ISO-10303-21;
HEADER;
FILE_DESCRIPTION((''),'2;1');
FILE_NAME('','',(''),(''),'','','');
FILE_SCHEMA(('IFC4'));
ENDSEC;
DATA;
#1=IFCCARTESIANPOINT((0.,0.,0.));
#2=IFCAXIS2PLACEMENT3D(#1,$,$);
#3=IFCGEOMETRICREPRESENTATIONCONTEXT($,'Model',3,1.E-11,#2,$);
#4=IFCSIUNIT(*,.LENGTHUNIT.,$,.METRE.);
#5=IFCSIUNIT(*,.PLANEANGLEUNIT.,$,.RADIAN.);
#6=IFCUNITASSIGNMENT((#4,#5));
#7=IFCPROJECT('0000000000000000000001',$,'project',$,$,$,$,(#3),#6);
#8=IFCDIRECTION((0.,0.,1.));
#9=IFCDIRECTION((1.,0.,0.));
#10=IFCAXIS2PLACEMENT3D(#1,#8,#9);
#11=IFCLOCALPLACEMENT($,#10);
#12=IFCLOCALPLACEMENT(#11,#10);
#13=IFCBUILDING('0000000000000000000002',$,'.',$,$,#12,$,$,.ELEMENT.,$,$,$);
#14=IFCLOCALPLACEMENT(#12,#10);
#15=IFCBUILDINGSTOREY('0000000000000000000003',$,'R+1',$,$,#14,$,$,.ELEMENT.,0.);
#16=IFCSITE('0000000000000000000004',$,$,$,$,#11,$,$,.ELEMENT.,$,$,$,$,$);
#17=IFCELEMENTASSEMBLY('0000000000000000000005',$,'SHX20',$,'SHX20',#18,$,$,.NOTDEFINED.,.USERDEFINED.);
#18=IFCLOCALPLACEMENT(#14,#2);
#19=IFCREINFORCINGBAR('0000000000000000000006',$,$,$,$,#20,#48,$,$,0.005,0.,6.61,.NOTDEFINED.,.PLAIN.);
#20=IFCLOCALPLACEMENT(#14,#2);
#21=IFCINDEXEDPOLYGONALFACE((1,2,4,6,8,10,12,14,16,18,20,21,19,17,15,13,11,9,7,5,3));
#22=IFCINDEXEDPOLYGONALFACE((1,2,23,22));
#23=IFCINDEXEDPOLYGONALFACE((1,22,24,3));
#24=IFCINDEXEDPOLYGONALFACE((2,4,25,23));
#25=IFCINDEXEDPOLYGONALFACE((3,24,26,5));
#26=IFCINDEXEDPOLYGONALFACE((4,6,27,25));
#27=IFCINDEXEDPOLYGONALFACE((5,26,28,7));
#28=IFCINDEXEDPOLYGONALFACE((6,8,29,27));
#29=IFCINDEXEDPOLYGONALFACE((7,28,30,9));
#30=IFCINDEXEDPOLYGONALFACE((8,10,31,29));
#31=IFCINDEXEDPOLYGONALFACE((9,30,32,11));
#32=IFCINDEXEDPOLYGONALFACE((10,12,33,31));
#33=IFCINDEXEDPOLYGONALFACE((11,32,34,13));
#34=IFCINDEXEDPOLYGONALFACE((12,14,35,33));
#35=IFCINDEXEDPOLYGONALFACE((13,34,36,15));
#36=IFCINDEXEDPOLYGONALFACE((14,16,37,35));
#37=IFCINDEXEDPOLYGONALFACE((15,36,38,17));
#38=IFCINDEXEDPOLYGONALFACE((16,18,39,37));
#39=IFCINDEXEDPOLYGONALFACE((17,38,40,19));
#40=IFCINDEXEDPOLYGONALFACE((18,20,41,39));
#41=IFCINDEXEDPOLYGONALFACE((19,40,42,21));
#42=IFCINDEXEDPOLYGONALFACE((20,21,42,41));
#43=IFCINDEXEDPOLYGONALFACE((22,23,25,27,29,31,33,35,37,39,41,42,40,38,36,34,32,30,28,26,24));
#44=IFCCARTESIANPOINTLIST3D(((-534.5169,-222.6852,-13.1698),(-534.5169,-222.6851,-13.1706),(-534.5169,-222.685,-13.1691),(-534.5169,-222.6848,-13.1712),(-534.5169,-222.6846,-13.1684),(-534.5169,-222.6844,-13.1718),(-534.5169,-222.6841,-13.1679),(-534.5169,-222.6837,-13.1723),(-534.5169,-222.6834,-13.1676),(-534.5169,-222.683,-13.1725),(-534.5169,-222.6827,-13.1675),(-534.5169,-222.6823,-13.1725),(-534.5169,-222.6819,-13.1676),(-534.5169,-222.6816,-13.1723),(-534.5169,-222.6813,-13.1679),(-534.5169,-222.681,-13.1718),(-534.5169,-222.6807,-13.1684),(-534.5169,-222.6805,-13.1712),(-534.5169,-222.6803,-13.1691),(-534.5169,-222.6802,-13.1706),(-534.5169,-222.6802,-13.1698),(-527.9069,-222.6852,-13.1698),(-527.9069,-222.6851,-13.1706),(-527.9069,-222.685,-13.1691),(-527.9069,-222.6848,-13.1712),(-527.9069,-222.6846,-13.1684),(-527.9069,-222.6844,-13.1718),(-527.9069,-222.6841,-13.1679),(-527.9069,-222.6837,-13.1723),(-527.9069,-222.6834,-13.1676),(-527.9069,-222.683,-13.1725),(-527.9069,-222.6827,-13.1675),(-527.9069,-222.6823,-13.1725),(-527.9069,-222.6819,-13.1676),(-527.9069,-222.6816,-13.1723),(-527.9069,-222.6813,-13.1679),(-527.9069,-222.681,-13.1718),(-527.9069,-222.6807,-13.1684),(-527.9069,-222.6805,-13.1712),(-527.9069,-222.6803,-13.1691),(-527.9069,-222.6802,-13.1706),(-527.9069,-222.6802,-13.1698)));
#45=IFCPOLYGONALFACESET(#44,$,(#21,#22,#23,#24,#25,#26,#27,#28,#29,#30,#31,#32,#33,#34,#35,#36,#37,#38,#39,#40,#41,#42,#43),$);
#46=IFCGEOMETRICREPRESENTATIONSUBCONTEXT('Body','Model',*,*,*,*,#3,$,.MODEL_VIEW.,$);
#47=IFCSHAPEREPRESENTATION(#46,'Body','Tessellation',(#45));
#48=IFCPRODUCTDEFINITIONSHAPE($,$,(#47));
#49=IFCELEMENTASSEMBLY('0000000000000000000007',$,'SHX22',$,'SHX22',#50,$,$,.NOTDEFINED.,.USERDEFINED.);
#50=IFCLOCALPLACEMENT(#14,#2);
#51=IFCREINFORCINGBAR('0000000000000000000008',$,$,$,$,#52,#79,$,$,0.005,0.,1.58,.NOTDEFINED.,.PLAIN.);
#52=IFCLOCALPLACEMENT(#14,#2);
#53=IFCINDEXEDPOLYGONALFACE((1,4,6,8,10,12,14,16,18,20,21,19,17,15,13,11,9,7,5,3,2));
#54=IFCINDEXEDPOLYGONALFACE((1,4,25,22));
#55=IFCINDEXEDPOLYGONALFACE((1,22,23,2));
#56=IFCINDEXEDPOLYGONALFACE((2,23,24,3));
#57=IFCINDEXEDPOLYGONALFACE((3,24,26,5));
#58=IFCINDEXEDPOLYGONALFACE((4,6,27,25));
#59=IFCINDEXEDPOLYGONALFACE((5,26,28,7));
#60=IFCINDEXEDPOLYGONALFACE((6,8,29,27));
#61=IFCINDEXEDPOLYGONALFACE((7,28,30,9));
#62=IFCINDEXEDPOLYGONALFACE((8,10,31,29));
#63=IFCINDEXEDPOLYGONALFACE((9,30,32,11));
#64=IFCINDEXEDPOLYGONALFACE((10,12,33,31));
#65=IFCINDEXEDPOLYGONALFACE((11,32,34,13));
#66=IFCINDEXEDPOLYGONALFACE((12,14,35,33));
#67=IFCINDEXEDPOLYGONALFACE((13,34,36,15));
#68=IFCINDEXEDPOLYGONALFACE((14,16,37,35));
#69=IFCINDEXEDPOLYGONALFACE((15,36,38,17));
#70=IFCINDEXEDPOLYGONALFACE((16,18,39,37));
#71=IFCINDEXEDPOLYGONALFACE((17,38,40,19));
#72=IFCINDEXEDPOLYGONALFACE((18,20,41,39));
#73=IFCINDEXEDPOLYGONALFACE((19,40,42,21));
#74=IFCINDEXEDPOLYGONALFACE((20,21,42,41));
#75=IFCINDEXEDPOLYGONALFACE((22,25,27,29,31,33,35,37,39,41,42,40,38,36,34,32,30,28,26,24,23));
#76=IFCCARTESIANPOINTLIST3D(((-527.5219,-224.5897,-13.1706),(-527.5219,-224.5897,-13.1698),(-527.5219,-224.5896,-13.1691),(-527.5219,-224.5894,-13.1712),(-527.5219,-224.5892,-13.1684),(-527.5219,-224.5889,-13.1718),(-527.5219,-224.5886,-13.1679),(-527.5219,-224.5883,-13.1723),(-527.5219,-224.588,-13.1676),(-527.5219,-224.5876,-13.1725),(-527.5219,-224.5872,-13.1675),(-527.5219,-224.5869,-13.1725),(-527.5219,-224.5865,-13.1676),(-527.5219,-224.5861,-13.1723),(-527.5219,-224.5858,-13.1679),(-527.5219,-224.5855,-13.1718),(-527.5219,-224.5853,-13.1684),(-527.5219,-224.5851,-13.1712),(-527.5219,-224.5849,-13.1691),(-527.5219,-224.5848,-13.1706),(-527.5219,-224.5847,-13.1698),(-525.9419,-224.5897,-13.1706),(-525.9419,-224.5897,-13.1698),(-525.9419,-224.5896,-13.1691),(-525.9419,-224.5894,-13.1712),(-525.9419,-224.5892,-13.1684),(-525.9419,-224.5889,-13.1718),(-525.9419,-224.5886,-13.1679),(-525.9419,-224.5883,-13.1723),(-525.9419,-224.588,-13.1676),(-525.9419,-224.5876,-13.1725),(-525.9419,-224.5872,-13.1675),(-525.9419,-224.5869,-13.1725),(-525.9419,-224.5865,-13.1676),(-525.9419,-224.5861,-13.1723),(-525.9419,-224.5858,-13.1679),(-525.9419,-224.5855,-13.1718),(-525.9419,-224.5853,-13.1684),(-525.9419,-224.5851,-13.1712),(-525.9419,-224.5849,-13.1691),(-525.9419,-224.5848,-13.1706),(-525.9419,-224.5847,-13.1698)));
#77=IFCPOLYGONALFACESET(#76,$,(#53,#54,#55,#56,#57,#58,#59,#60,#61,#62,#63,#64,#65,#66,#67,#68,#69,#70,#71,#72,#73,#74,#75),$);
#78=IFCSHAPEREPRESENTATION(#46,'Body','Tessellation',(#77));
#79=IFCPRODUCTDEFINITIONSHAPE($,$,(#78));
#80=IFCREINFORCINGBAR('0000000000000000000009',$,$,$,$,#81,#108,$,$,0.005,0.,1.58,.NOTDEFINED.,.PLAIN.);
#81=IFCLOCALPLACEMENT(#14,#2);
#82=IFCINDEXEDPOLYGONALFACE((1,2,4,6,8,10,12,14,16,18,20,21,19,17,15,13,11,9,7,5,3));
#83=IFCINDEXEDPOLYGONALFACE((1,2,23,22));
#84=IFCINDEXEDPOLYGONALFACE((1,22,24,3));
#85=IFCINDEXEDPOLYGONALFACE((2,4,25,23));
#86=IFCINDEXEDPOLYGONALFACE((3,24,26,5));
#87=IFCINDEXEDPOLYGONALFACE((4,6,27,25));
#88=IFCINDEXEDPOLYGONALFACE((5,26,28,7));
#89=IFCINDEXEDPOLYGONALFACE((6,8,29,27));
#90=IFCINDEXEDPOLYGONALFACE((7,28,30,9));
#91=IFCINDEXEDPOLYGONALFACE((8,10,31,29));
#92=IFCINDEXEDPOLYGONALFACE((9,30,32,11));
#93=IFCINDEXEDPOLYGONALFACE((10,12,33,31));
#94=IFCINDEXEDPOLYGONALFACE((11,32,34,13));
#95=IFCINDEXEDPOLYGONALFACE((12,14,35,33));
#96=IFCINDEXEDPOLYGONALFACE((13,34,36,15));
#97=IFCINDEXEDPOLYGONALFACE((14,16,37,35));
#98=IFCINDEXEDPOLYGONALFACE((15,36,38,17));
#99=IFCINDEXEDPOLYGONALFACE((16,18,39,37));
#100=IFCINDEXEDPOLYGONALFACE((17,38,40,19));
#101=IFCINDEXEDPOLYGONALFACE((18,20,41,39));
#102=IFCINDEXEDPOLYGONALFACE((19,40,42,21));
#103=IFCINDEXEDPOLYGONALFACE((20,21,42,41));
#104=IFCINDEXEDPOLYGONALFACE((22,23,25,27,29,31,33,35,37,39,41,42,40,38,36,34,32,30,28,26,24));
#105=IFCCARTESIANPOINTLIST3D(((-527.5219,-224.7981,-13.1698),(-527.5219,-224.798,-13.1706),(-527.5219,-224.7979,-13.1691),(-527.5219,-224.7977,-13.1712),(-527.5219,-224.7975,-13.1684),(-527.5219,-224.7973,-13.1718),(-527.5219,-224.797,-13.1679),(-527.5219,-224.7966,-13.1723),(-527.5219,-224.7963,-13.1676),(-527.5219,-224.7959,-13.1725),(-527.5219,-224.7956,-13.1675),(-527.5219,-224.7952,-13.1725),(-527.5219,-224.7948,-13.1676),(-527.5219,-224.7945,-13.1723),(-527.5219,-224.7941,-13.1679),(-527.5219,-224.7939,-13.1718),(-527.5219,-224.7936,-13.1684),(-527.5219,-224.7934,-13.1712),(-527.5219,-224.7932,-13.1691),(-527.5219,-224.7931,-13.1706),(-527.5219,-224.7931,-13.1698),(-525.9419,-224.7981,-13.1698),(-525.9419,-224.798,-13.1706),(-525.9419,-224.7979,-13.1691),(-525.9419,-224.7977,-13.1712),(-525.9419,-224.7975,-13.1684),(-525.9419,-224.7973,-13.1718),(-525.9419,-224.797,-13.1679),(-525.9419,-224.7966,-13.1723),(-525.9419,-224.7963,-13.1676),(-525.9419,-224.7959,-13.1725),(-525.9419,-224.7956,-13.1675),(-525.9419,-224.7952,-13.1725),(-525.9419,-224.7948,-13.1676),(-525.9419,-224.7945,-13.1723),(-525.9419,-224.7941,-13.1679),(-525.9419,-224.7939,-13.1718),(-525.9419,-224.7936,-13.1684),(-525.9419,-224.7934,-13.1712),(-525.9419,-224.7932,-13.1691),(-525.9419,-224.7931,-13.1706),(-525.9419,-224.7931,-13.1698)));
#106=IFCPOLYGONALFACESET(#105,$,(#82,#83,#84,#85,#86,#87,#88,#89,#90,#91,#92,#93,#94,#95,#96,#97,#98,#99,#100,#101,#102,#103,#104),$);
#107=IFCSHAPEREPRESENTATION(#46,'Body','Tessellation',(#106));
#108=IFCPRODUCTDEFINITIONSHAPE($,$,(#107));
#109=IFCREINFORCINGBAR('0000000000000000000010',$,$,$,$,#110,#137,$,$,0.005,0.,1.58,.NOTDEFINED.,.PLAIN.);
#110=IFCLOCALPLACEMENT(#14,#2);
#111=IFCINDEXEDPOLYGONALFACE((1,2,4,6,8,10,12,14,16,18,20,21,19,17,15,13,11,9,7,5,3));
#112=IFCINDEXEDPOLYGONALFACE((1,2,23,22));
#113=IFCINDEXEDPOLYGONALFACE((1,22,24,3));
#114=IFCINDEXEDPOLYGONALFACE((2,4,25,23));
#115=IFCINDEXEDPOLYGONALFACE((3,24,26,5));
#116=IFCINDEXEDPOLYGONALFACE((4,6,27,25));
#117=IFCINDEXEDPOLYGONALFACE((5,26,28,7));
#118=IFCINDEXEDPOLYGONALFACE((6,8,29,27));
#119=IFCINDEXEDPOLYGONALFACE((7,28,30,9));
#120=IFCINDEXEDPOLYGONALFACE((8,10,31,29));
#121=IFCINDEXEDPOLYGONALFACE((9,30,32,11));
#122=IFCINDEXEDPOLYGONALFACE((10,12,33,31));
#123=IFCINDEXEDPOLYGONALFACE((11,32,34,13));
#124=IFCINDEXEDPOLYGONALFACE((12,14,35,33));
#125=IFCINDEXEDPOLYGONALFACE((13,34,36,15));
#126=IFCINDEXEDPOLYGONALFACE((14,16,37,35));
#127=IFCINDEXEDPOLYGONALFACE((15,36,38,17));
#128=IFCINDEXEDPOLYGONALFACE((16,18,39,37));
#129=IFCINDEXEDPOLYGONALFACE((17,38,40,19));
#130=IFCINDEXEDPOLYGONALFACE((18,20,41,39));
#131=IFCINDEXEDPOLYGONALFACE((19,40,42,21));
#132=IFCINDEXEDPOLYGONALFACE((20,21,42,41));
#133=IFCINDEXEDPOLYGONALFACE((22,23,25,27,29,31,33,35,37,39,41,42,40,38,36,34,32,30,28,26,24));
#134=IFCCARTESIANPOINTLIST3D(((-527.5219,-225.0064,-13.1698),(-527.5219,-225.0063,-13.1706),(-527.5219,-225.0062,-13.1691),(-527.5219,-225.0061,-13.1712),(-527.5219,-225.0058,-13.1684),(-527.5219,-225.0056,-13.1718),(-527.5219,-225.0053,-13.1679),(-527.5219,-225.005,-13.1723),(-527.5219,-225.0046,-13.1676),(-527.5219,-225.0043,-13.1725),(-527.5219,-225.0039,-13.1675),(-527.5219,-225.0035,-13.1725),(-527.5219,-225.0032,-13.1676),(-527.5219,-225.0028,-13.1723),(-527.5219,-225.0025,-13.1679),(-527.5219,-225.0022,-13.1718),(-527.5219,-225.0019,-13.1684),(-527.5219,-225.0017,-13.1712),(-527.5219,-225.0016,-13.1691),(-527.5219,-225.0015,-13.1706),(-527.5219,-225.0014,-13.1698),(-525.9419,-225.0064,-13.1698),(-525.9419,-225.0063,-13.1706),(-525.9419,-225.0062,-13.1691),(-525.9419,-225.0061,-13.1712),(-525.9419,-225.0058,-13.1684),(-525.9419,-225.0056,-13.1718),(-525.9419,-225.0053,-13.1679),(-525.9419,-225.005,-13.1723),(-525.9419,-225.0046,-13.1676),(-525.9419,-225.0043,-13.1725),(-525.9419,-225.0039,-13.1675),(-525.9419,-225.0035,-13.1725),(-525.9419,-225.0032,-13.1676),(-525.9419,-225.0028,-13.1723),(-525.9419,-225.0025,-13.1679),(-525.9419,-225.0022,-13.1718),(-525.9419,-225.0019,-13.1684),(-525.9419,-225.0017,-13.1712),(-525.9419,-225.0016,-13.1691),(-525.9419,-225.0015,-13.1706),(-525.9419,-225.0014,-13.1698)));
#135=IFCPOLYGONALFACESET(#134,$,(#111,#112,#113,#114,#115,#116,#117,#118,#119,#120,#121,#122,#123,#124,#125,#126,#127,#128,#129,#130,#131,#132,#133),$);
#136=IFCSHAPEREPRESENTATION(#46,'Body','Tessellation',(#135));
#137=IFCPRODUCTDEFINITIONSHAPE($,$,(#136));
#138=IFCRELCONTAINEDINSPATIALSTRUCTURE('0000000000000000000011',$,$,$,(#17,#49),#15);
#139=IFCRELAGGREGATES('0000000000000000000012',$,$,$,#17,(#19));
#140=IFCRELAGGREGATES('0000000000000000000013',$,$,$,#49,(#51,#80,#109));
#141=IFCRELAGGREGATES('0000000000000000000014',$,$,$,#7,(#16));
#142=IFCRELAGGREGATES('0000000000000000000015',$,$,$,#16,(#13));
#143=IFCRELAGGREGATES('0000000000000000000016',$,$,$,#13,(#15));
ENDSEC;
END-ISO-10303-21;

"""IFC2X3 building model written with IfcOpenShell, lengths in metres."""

from ifc_helpers import new_model, entity, si_unit, origin, origin_with_axes, place, context, subcontext, project, spatial, shape, element, aggregate, save


model = new_model("IFC2X3")

# Units and contexts
model_context = context("Model", 3, precision=1e-11, world=origin())
body_context = subcontext(model_context, "Body", "Model", "MODEL_VIEW")
ifc_project = project(units=[si_unit("LENGTHUNIT", "METRE"), si_unit("PLANEANGLEUNIT", "RADIAN")], contexts=[model_context])

# Site, building, storey
site_placement = place(None, origin_with_axes())
site = spatial("IfcSite", under=ifc_project, at=site_placement, CompositionType="ELEMENT")
building_placement = place(site_placement, origin_with_axes())
building = spatial("IfcBuilding", under=site, at=building_placement, Name=".", CompositionType="ELEMENT")
storey_placement = place(building_placement, origin_with_axes())
storey = spatial("IfcBuildingStorey", under=building, at=storey_placement, Name="R+1", CompositionType="ELEMENT", Elevation=0.0)

# Element assemblies, reinforcing bars
assembly_1_placement = place(storey_placement, origin_with_axes())
assembly_1 = element("IfcElementAssembly", 1, at=assembly_1_placement, inside=storey, Name="SHX20", ObjectType="SHX20", AssemblyPlace="NOTDEFINED", PredefinedType="USERDEFINED")
reinforcing_bar_1_placement = place(assembly_1_placement, origin_with_axes())
reinforcing_bar_1 = element("IfcReinforcingBar", 2, at=reinforcing_bar_1_placement, BarLength=6.61, BarRole="NOTDEFINED", BarSurface="PLAIN", CrossSectionArea=0.0, NominalDiameter=0.005, shapes=[
    shape(body_context, "Body", "AdvancedSweptSolid", [entity("IfcSweptDiskSolid", entity("IfcPolyline", [entity("IfcCartesianPoint", [527.9069, 222.6827, 13.17]), entity("IfcCartesianPoint", [534.5169, 222.6827, 13.17])]), 0.0025, None, 0.0, 6.61)]),
    shape(body_context, "Body", "AdvancedSweptSolid", [entity("IfcSweptDiskSolid", entity("IfcPolyline", [entity("IfcCartesianPoint", [527.9069, 222.6827, 13.17]), entity("IfcCartesianPoint", [534.5169, 222.6827, 13.17])]), 0.0025, None, 0.0, 6.61)]),
])
aggregate(assembly_1, [reinforcing_bar_1])
assembly_2_placement = place(storey_placement, origin_with_axes())
assembly_2 = element("IfcElementAssembly", 3, at=assembly_2_placement, inside=storey, Name="SHX22", ObjectType="SHX22", AssemblyPlace="NOTDEFINED", PredefinedType="USERDEFINED")
reinforcing_bar_2_placement = place(assembly_2_placement, origin_with_axes())
reinforcing_bar_2 = element("IfcReinforcingBar", 4, at=reinforcing_bar_2_placement, BarLength=1.58, BarRole="NOTDEFINED", BarSurface="PLAIN", CrossSectionArea=0.0, NominalDiameter=0.005, shapes=[
    shape(body_context, "Body", "AdvancedSweptSolid", [entity("IfcSweptDiskSolid", entity("IfcPolyline", [entity("IfcCartesianPoint", [525.9419, 224.5872, 13.17]), entity("IfcCartesianPoint", [527.5219, 224.5872, 13.17])]), 0.0025, None, 0.0, 1.58)]),
    shape(body_context, "Body", "AdvancedSweptSolid", [entity("IfcSweptDiskSolid", entity("IfcPolyline", [entity("IfcCartesianPoint", [525.9419, 224.5872, 13.17]), entity("IfcCartesianPoint", [527.5219, 224.5872, 13.17])]), 0.0025, None, 0.0, 1.58)]),
])
reinforcing_bar_3_placement = place(assembly_2_placement, origin_with_axes())
reinforcing_bar_3 = element("IfcReinforcingBar", 5, at=reinforcing_bar_3_placement, BarLength=1.58, BarRole="NOTDEFINED", BarSurface="PLAIN", CrossSectionArea=0.0, NominalDiameter=0.005, shapes=[
    shape(body_context, "Body", "AdvancedSweptSolid", [entity("IfcSweptDiskSolid", entity("IfcPolyline", [entity("IfcCartesianPoint", [525.9419, 224.7956, 13.17]), entity("IfcCartesianPoint", [527.5219, 224.7956, 13.17])]), 0.0025, None, 0.0, 1.58)]),
    shape(body_context, "Body", "AdvancedSweptSolid", [entity("IfcSweptDiskSolid", entity("IfcPolyline", [entity("IfcCartesianPoint", [525.9419, 224.7956, 13.17]), entity("IfcCartesianPoint", [527.5219, 224.7956, 13.17])]), 0.0025, None, 0.0, 1.58)]),
])
reinforcing_bar_4_placement = place(assembly_2_placement, origin_with_axes())
reinforcing_bar_4 = element("IfcReinforcingBar", 6, at=reinforcing_bar_4_placement, BarLength=1.58, BarRole="NOTDEFINED", BarSurface="PLAIN", CrossSectionArea=0.0, NominalDiameter=0.005, shapes=[
    shape(body_context, "Body", "AdvancedSweptSolid", [entity("IfcSweptDiskSolid", entity("IfcPolyline", [entity("IfcCartesianPoint", [525.9419, 225.0039, 13.17]), entity("IfcCartesianPoint", [527.5219, 225.0039, 13.17])]), 0.0025, None, 0.0, 1.58)]),
    shape(body_context, "Body", "AdvancedSweptSolid", [entity("IfcSweptDiskSolid", entity("IfcPolyline", [entity("IfcCartesianPoint", [525.9419, 225.0039, 13.17]), entity("IfcCartesianPoint", [527.5219, 225.0039, 13.17])]), 0.0025, None, 0.0, 1.58)]),
])
aggregate(assembly_2, [reinforcing_bar_2, reinforcing_bar_3, reinforcing_bar_4])

save(model, "model.ifc")
